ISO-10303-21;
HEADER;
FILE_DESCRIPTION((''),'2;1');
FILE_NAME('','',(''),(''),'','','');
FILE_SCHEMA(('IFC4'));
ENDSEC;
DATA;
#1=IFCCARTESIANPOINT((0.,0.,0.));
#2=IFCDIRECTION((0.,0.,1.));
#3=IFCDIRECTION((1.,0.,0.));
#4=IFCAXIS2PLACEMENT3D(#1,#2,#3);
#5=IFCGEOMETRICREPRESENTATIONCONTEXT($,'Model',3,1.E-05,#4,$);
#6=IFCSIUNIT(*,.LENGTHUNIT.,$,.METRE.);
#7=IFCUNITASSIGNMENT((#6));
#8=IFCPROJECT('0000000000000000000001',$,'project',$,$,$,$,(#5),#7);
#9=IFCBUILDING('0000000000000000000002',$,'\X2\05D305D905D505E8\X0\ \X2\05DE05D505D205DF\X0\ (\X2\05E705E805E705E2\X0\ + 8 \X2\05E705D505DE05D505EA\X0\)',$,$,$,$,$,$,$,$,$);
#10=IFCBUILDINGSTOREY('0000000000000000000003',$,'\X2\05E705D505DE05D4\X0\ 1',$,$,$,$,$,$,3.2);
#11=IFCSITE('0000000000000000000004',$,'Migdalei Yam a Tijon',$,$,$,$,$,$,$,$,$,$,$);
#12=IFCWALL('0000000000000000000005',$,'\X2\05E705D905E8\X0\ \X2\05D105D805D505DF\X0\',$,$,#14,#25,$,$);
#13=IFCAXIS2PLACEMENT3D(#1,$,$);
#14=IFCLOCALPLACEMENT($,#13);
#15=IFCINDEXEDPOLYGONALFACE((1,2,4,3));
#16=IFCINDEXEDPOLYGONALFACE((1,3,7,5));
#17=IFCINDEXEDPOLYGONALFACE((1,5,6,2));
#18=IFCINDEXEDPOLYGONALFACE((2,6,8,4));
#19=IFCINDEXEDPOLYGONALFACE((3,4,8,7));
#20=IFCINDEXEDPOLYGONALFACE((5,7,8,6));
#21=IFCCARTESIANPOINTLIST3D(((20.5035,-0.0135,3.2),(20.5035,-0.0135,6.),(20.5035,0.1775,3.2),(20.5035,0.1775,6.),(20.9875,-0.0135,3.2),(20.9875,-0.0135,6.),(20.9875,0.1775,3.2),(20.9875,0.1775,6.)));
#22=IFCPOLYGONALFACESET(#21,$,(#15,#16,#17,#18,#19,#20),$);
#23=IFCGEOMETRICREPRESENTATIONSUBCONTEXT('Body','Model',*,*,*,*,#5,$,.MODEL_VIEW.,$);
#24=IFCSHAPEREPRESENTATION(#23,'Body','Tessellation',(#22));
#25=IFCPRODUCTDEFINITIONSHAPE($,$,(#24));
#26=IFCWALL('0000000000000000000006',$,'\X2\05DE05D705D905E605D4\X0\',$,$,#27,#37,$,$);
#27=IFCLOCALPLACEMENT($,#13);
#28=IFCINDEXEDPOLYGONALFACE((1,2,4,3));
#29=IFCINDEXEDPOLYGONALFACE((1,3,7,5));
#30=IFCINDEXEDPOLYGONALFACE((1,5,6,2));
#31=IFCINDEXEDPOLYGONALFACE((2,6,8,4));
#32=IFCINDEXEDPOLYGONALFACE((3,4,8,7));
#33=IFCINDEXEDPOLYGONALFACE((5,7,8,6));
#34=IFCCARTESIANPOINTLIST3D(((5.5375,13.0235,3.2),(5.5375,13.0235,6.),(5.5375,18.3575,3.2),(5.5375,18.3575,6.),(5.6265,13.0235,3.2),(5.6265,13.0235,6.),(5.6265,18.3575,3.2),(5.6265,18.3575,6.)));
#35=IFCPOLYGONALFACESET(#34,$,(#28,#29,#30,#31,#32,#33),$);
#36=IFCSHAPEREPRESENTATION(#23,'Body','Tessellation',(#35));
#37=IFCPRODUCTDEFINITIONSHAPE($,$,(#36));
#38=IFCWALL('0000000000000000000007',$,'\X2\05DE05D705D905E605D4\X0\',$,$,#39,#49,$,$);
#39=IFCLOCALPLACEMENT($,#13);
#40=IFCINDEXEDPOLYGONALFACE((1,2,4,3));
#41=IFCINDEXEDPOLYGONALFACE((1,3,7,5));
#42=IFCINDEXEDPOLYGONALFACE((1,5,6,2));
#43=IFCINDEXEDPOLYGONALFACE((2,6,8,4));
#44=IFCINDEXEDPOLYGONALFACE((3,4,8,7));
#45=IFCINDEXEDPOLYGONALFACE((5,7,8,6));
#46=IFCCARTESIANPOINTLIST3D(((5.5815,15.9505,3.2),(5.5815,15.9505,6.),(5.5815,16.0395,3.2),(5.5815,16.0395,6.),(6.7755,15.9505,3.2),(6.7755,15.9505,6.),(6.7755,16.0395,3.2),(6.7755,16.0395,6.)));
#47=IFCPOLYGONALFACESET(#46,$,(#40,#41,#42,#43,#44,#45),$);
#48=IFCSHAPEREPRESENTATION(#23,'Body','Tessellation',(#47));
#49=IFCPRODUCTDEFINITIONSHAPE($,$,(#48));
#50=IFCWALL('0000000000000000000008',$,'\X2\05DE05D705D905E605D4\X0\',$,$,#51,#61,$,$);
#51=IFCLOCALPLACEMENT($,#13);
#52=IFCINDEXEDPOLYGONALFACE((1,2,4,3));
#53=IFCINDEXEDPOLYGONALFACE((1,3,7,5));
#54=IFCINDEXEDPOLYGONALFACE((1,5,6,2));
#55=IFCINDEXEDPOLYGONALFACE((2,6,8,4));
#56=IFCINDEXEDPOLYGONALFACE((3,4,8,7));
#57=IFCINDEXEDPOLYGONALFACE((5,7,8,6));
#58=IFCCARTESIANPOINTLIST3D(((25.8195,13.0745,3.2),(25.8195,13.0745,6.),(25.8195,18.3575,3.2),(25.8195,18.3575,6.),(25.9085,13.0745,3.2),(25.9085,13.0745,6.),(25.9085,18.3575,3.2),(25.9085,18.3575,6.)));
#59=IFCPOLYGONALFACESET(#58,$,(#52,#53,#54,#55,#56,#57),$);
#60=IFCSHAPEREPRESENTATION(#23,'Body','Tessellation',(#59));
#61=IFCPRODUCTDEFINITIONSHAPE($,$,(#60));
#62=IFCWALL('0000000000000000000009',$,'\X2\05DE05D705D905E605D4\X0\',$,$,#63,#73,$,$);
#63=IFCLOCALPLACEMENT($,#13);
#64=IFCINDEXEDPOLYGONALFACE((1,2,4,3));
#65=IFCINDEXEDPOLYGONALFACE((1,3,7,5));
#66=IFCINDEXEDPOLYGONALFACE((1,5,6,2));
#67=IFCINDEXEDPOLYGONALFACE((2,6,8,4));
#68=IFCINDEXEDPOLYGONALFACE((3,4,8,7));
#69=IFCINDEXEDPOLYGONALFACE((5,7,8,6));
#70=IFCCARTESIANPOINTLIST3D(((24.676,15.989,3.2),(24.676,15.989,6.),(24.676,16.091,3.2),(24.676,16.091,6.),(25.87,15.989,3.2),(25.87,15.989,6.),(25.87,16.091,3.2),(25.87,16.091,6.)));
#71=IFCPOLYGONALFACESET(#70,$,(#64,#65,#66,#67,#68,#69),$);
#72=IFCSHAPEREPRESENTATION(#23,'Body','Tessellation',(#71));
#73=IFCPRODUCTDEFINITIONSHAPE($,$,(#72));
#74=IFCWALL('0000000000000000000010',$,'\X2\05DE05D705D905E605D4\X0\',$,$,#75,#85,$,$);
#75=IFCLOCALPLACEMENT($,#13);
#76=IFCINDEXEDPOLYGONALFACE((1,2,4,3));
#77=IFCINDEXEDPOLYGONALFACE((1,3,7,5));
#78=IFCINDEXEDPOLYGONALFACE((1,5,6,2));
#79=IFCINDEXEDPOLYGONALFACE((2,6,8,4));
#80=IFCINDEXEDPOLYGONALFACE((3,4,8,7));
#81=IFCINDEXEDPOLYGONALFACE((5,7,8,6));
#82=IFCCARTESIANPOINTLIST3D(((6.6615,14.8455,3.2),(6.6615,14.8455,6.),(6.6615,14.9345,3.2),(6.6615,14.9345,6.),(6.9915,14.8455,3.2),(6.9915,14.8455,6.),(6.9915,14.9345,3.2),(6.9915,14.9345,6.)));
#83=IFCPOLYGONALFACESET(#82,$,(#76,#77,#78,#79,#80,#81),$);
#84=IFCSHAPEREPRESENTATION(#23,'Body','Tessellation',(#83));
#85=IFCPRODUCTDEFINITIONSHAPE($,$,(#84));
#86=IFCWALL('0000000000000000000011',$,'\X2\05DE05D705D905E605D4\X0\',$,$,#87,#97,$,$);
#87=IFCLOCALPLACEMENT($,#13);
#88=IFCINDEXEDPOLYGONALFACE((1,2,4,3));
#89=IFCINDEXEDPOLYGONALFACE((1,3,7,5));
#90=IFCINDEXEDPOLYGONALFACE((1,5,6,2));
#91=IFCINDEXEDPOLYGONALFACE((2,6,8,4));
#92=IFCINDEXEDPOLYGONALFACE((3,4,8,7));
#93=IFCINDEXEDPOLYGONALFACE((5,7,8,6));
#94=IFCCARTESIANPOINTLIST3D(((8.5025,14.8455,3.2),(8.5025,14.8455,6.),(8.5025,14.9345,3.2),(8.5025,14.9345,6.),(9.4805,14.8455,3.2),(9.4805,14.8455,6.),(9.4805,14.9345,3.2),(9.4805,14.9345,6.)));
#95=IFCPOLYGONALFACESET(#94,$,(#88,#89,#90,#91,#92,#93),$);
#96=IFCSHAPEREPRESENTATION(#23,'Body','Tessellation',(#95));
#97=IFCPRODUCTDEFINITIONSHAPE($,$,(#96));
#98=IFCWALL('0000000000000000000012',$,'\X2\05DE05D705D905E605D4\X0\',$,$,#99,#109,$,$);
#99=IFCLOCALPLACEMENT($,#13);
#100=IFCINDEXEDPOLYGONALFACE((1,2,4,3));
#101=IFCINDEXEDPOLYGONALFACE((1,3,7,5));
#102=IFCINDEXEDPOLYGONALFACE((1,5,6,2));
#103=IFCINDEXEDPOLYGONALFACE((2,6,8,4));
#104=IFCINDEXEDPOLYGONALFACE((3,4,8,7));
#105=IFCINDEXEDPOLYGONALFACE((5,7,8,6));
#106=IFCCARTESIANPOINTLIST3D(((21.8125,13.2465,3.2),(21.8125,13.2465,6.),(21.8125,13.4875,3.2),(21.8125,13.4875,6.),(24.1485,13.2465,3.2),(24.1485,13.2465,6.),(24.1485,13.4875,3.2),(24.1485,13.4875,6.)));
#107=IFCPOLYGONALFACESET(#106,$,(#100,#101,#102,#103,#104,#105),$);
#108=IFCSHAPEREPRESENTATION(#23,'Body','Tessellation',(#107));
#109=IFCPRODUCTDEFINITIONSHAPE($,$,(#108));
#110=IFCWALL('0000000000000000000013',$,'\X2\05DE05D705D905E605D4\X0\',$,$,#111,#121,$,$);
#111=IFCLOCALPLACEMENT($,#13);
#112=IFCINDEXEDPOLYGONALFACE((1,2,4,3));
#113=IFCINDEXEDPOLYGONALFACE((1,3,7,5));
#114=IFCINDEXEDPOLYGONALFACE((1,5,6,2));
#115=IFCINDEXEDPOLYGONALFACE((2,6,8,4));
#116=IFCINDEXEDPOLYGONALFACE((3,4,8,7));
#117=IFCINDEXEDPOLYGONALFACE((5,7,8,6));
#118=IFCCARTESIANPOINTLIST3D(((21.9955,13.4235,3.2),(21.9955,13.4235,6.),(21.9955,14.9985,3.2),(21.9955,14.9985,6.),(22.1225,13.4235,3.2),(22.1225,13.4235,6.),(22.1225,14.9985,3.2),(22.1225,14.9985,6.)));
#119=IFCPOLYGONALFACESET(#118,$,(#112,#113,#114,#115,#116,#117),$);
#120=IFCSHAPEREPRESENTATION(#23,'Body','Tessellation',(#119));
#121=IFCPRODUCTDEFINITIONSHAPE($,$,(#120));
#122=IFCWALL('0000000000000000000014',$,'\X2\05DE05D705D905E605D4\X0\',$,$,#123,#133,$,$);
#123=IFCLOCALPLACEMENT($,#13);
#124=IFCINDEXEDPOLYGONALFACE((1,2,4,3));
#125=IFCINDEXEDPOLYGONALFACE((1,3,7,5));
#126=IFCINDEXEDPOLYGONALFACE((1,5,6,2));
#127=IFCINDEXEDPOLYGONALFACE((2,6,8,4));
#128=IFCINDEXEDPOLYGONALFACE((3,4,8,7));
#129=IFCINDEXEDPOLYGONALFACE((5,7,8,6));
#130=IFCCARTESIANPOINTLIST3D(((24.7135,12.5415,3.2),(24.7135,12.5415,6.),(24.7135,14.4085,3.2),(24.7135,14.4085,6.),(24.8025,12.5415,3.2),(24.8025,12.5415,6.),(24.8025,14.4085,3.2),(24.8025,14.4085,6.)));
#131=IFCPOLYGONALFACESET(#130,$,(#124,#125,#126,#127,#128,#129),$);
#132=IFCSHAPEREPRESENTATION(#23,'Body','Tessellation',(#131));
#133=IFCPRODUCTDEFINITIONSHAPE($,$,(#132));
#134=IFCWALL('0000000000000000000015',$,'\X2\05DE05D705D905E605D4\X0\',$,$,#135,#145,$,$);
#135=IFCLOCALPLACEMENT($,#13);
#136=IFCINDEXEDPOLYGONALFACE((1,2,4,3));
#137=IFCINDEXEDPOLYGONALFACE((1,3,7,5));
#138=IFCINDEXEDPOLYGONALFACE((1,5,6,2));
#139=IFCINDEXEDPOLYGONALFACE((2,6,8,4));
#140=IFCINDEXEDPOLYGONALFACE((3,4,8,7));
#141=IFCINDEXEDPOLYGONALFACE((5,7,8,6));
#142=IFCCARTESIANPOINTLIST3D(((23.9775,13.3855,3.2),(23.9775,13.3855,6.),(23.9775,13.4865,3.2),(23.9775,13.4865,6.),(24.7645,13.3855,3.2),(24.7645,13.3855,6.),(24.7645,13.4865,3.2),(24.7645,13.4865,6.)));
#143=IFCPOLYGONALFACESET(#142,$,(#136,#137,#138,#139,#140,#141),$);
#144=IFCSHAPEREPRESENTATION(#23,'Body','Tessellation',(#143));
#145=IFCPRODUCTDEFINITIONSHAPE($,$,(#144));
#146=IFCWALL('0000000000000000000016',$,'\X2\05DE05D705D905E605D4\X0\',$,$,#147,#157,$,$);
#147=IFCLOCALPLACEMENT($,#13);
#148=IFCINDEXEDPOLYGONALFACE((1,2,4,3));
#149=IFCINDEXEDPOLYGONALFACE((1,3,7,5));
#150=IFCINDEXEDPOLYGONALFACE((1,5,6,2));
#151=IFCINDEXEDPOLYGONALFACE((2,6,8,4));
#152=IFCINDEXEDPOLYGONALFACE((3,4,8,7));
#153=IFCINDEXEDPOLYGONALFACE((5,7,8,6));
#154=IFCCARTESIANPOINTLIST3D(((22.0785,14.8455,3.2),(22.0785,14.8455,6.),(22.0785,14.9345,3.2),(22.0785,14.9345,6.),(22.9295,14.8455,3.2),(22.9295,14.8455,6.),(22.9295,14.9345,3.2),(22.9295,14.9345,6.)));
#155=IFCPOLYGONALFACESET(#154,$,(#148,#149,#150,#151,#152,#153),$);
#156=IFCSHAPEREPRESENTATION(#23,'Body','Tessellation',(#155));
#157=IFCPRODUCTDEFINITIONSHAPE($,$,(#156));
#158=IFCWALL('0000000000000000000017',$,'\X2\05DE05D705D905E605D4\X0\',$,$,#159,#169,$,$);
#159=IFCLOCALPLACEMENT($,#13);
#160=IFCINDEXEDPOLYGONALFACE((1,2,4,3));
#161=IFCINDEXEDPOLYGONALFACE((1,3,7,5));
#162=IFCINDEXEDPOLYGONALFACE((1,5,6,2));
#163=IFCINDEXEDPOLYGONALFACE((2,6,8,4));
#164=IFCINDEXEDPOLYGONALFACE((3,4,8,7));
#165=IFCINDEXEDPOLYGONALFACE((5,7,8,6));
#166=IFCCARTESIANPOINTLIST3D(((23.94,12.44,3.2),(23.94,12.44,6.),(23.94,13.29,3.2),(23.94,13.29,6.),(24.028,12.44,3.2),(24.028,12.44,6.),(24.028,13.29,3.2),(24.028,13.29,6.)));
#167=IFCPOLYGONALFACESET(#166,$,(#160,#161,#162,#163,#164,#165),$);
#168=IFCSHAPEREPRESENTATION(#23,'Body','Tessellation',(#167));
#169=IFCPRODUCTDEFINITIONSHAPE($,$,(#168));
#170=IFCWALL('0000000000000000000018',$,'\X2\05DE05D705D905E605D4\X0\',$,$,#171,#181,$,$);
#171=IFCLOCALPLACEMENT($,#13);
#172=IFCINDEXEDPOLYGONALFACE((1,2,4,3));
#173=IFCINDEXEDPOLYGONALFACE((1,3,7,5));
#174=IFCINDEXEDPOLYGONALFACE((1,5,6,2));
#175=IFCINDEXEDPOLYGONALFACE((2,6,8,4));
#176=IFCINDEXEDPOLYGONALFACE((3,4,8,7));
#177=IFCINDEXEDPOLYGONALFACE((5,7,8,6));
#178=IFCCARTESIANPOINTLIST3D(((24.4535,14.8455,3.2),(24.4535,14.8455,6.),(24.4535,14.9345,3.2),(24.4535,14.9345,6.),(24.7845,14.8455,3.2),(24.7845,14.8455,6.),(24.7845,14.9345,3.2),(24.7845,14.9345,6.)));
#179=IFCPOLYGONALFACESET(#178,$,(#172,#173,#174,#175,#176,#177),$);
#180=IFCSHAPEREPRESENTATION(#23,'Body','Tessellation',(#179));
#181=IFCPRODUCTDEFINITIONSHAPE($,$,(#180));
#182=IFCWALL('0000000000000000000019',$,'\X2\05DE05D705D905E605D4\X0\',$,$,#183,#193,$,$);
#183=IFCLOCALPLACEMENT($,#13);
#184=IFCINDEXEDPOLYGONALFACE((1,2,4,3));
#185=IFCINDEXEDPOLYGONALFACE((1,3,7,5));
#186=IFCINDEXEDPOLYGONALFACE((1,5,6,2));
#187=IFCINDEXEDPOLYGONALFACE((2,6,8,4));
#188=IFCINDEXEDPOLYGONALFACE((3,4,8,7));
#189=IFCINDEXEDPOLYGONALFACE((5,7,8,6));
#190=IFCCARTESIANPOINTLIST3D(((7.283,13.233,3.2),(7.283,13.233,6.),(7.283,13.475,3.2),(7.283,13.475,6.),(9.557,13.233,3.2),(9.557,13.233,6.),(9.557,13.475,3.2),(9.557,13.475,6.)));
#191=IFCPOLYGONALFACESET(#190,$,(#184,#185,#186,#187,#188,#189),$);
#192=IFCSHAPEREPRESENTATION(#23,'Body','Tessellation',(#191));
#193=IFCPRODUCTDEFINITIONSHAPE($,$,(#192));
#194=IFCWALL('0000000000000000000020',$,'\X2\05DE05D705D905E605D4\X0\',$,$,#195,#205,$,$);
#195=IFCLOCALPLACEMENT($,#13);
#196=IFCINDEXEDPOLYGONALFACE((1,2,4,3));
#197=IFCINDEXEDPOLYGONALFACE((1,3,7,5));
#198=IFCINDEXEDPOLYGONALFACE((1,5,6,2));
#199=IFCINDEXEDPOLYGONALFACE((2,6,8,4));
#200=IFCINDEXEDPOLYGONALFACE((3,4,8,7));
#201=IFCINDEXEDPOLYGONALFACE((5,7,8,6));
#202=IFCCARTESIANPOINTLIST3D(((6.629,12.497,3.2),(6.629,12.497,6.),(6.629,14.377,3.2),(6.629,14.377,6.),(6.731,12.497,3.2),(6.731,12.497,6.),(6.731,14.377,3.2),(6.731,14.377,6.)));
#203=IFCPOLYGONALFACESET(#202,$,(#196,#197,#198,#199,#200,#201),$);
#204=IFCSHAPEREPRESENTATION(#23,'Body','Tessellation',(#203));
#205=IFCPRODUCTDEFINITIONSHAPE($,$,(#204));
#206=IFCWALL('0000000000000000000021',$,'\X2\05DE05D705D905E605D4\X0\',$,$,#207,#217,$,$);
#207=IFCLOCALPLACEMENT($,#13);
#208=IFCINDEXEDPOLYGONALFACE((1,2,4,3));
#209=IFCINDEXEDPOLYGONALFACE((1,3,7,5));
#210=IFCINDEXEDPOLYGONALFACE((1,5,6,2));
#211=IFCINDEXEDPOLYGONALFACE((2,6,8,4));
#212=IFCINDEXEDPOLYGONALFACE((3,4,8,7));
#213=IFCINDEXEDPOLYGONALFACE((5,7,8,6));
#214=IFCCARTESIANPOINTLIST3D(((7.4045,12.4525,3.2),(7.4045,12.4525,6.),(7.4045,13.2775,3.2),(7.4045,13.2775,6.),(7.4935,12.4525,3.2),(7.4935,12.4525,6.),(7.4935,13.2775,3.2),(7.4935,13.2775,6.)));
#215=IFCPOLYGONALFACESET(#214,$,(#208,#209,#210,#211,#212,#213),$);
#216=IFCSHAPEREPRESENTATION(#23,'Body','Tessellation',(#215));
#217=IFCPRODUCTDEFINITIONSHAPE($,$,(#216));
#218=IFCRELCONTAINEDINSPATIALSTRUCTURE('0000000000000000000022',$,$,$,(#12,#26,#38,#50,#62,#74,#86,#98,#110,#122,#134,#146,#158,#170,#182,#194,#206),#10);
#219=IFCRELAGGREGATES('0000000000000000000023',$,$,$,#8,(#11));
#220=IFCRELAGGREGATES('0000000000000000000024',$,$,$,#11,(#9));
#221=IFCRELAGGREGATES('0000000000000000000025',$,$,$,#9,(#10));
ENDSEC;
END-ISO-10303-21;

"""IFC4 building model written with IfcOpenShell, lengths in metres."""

from ifc_helpers import new_model, si_unit, frame, origin_with_axes, context, subcontext, project, spatial, line, indexed_curve, outline, extrude, element, save


model = new_model("IFC4")

# Units and contexts
model_context = context("Model", 3, precision=1e-05, world=origin_with_axes())
body_context = subcontext(model_context, "Body", "Model", "MODEL_VIEW")
ifc_project = project(units=[si_unit("LENGTHUNIT", "METRE")], contexts=[model_context])

# Site, building, storey
site = spatial("IfcSite", under=ifc_project, Name="Migdalei Yam a Tijon")
building = spatial("IfcBuilding", under=site, Name="דיור מוגן (קרקע + 8 קומות)")
storey = spatial("IfcBuildingStorey", under=building, Name="קומה 1", Elevation=3.2)

# Walls
element("IfcWall", 1, inside=storey, Name="קיר בטון", context=body_context, shape_type="SweptSolid", body=[
    extrude(outline(indexed_curve([(0.0, 0.0), (0.484, 0.0), (0.484, 0.191), (0.0, 0.191)], segments=[line(1, 2, 3, 4, 1)])), frame((20.5035, -0.0135, 3.2), z_axis=(0.0, 0.0, 1.0), x_axis=(1.0, 0.0, 0.0)), (0.0, 0.0, 1.0), 2.8),
])
element("IfcWall", 2, inside=storey, Name="מחיצה", context=body_context, shape_type="SweptSolid", body=[
    extrude(outline(indexed_curve([(0.0, 0.0), (0.089, 0.0), (0.089, 5.334), (0.0, 5.334)], segments=[line(1, 2, 3, 4, 1)])), frame((5.5375, 13.0235, 3.2), z_axis=(0.0, 0.0, 1.0), x_axis=(1.0, 0.0, 0.0)), (0.0, 0.0, 1.0), 2.8),
])
element("IfcWall", 3, inside=storey, Name="מחיצה", context=body_context, shape_type="SweptSolid", body=[
    extrude(outline(indexed_curve([(0.0, 0.0), (1.194, 0.0), (1.194, 0.089), (0.0, 0.089)], segments=[line(1, 2, 3, 4, 1)])), frame((5.5815, 15.9505, 3.2), z_axis=(0.0, 0.0, 1.0), x_axis=(1.0, 0.0, 0.0)), (0.0, 0.0, 1.0), 2.8),
])
element("IfcWall", 4, inside=storey, Name="מחיצה", context=body_context, shape_type="SweptSolid", body=[
    extrude(outline(indexed_curve([(0.0, 0.0), (0.089, 0.0), (0.089, 5.283), (0.0, 5.283)], segments=[line(1, 2, 3, 4, 1)])), frame((25.8195, 13.0745, 3.2), z_axis=(0.0, 0.0, 1.0), x_axis=(1.0, 0.0, 0.0)), (0.0, 0.0, 1.0), 2.8),
])
element("IfcWall", 5, inside=storey, Name="מחיצה", context=body_context, shape_type="SweptSolid", body=[
    extrude(outline(indexed_curve([(0.0, 0.0), (1.194, 0.0), (1.194, 0.102), (0.0, 0.102)], segments=[line(1, 2, 3, 4, 1)])), frame((24.676, 15.989, 3.2), z_axis=(0.0, 0.0, 1.0), x_axis=(1.0, 0.0, 0.0)), (0.0, 0.0, 1.0), 2.8),
])
element("IfcWall", 6, inside=storey, Name="מחיצה", context=body_context, shape_type="SweptSolid", body=[
    extrude(outline(indexed_curve([(0.0, 0.0), (0.33, 0.0), (0.33, 0.089), (0.0, 0.089)], segments=[line(1, 2, 3, 4, 1)])), frame((6.6615, 14.8455, 3.2), z_axis=(0.0, 0.0, 1.0), x_axis=(1.0, 0.0, 0.0)), (0.0, 0.0, 1.0), 2.8),
])
element("IfcWall", 7, inside=storey, Name="מחיצה", context=body_context, shape_type="SweptSolid", body=[
    extrude(outline(indexed_curve([(0.0, 0.0), (0.978, 0.0), (0.978, 0.089), (0.0, 0.089)], segments=[line(1, 2, 3, 4, 1)])), frame((8.5025, 14.8455, 3.2), z_axis=(0.0, 0.0, 1.0), x_axis=(1.0, 0.0, 0.0)), (0.0, 0.0, 1.0), 2.8),
])
element("IfcWall", 8, inside=storey, Name="מחיצה", context=body_context, shape_type="SweptSolid", body=[
    extrude(outline(indexed_curve([(0.0, 0.0), (2.336, 0.0), (2.336, 0.241), (0.0, 0.241)], segments=[line(1, 2, 3, 4, 1)])), frame((21.8125, 13.2465, 3.2), z_axis=(0.0, 0.0, 1.0), x_axis=(1.0, 0.0, 0.0)), (0.0, 0.0, 1.0), 2.8),
])
element("IfcWall", 9, inside=storey, Name="מחיצה", context=body_context, shape_type="SweptSolid", body=[
    extrude(outline(indexed_curve([(0.0, 0.0), (0.127, 0.0), (0.127, 1.575), (0.0, 1.575)], segments=[line(1, 2, 3, 4, 1)])), frame((21.9955, 13.4235, 3.2), z_axis=(0.0, 0.0, 1.0), x_axis=(1.0, 0.0, 0.0)), (0.0, 0.0, 1.0), 2.8),
])
element("IfcWall", 10, inside=storey, Name="מחיצה", context=body_context, shape_type="SweptSolid", body=[
    extrude(outline(indexed_curve([(0.0, 0.0), (0.089, 0.0), (0.089, 1.867), (0.0, 1.867)], segments=[line(1, 2, 3, 4, 1)])), frame((24.7135, 12.5415, 3.2), z_axis=(0.0, 0.0, 1.0), x_axis=(1.0, 0.0, 0.0)), (0.0, 0.0, 1.0), 2.8),
])
element("IfcWall", 11, inside=storey, Name="מחיצה", context=body_context, shape_type="SweptSolid", body=[
    extrude(outline(indexed_curve([(0.0, 0.0), (0.787, 0.0), (0.787, 0.101), (0.0, 0.101)], segments=[line(1, 2, 3, 4, 1)])), frame((23.9775, 13.3855, 3.2), z_axis=(0.0, 0.0, 1.0), x_axis=(1.0, 0.0, 0.0)), (0.0, 0.0, 1.0), 2.8),
])
element("IfcWall", 12, inside=storey, Name="מחיצה", context=body_context, shape_type="SweptSolid", body=[
    extrude(outline(indexed_curve([(0.0, 0.0), (0.851, 0.0), (0.851, 0.089), (0.0, 0.089)], segments=[line(1, 2, 3, 4, 1)])), frame((22.0785, 14.8455, 3.2), z_axis=(0.0, 0.0, 1.0), x_axis=(1.0, 0.0, 0.0)), (0.0, 0.0, 1.0), 2.8),
])
element("IfcWall", 13, inside=storey, Name="מחיצה", context=body_context, shape_type="SweptSolid", body=[
    extrude(outline(indexed_curve([(0.0, 0.0), (0.088, 0.0), (0.088, 0.85), (0.0, 0.85)], segments=[line(1, 2, 3, 4, 1)])), frame((23.94, 12.44, 3.2), z_axis=(0.0, 0.0, 1.0), x_axis=(1.0, 0.0, 0.0)), (0.0, 0.0, 1.0), 2.8),
])
element("IfcWall", 14, inside=storey, Name="מחיצה", context=body_context, shape_type="SweptSolid", body=[
    extrude(outline(indexed_curve([(0.0, 0.0), (0.331, 0.0), (0.331, 0.089), (0.0, 0.089)], segments=[line(1, 2, 3, 4, 1)])), frame((24.4535, 14.8455, 3.2), z_axis=(0.0, 0.0, 1.0), x_axis=(1.0, 0.0, 0.0)), (0.0, 0.0, 1.0), 2.8),
])
element("IfcWall", 15, inside=storey, Name="מחיצה", context=body_context, shape_type="SweptSolid", body=[
    extrude(outline(indexed_curve([(0.0, 0.0), (2.274, 0.0), (2.274, 0.242), (0.0, 0.242)], segments=[line(1, 2, 3, 4, 1)])), frame((7.283, 13.233, 3.2), z_axis=(0.0, 0.0, 1.0), x_axis=(1.0, 0.0, 0.0)), (0.0, 0.0, 1.0), 2.8),
])
element("IfcWall", 16, inside=storey, Name="מחיצה", context=body_context, shape_type="SweptSolid", body=[
    extrude(outline(indexed_curve([(0.0, 0.0), (0.102, 0.0), (0.102, 1.88), (0.0, 1.88)], segments=[line(1, 2, 3, 4, 1)])), frame((6.629, 12.497, 3.2), z_axis=(0.0, 0.0, 1.0), x_axis=(1.0, 0.0, 0.0)), (0.0, 0.0, 1.0), 2.8),
])
element("IfcWall", 17, inside=storey, Name="מחיצה", context=body_context, shape_type="SweptSolid", body=[
    extrude(outline(indexed_curve([(0.0, 0.0), (0.089, 0.0), (0.089, 0.825), (0.0, 0.825)], segments=[line(1, 2, 3, 4, 1)])), frame((7.4045, 12.4525, 3.2), z_axis=(0.0, 0.0, 1.0), x_axis=(1.0, 0.0, 0.0)), (0.0, 0.0, 1.0), 2.8),
])

save(model, "model.ifc")
